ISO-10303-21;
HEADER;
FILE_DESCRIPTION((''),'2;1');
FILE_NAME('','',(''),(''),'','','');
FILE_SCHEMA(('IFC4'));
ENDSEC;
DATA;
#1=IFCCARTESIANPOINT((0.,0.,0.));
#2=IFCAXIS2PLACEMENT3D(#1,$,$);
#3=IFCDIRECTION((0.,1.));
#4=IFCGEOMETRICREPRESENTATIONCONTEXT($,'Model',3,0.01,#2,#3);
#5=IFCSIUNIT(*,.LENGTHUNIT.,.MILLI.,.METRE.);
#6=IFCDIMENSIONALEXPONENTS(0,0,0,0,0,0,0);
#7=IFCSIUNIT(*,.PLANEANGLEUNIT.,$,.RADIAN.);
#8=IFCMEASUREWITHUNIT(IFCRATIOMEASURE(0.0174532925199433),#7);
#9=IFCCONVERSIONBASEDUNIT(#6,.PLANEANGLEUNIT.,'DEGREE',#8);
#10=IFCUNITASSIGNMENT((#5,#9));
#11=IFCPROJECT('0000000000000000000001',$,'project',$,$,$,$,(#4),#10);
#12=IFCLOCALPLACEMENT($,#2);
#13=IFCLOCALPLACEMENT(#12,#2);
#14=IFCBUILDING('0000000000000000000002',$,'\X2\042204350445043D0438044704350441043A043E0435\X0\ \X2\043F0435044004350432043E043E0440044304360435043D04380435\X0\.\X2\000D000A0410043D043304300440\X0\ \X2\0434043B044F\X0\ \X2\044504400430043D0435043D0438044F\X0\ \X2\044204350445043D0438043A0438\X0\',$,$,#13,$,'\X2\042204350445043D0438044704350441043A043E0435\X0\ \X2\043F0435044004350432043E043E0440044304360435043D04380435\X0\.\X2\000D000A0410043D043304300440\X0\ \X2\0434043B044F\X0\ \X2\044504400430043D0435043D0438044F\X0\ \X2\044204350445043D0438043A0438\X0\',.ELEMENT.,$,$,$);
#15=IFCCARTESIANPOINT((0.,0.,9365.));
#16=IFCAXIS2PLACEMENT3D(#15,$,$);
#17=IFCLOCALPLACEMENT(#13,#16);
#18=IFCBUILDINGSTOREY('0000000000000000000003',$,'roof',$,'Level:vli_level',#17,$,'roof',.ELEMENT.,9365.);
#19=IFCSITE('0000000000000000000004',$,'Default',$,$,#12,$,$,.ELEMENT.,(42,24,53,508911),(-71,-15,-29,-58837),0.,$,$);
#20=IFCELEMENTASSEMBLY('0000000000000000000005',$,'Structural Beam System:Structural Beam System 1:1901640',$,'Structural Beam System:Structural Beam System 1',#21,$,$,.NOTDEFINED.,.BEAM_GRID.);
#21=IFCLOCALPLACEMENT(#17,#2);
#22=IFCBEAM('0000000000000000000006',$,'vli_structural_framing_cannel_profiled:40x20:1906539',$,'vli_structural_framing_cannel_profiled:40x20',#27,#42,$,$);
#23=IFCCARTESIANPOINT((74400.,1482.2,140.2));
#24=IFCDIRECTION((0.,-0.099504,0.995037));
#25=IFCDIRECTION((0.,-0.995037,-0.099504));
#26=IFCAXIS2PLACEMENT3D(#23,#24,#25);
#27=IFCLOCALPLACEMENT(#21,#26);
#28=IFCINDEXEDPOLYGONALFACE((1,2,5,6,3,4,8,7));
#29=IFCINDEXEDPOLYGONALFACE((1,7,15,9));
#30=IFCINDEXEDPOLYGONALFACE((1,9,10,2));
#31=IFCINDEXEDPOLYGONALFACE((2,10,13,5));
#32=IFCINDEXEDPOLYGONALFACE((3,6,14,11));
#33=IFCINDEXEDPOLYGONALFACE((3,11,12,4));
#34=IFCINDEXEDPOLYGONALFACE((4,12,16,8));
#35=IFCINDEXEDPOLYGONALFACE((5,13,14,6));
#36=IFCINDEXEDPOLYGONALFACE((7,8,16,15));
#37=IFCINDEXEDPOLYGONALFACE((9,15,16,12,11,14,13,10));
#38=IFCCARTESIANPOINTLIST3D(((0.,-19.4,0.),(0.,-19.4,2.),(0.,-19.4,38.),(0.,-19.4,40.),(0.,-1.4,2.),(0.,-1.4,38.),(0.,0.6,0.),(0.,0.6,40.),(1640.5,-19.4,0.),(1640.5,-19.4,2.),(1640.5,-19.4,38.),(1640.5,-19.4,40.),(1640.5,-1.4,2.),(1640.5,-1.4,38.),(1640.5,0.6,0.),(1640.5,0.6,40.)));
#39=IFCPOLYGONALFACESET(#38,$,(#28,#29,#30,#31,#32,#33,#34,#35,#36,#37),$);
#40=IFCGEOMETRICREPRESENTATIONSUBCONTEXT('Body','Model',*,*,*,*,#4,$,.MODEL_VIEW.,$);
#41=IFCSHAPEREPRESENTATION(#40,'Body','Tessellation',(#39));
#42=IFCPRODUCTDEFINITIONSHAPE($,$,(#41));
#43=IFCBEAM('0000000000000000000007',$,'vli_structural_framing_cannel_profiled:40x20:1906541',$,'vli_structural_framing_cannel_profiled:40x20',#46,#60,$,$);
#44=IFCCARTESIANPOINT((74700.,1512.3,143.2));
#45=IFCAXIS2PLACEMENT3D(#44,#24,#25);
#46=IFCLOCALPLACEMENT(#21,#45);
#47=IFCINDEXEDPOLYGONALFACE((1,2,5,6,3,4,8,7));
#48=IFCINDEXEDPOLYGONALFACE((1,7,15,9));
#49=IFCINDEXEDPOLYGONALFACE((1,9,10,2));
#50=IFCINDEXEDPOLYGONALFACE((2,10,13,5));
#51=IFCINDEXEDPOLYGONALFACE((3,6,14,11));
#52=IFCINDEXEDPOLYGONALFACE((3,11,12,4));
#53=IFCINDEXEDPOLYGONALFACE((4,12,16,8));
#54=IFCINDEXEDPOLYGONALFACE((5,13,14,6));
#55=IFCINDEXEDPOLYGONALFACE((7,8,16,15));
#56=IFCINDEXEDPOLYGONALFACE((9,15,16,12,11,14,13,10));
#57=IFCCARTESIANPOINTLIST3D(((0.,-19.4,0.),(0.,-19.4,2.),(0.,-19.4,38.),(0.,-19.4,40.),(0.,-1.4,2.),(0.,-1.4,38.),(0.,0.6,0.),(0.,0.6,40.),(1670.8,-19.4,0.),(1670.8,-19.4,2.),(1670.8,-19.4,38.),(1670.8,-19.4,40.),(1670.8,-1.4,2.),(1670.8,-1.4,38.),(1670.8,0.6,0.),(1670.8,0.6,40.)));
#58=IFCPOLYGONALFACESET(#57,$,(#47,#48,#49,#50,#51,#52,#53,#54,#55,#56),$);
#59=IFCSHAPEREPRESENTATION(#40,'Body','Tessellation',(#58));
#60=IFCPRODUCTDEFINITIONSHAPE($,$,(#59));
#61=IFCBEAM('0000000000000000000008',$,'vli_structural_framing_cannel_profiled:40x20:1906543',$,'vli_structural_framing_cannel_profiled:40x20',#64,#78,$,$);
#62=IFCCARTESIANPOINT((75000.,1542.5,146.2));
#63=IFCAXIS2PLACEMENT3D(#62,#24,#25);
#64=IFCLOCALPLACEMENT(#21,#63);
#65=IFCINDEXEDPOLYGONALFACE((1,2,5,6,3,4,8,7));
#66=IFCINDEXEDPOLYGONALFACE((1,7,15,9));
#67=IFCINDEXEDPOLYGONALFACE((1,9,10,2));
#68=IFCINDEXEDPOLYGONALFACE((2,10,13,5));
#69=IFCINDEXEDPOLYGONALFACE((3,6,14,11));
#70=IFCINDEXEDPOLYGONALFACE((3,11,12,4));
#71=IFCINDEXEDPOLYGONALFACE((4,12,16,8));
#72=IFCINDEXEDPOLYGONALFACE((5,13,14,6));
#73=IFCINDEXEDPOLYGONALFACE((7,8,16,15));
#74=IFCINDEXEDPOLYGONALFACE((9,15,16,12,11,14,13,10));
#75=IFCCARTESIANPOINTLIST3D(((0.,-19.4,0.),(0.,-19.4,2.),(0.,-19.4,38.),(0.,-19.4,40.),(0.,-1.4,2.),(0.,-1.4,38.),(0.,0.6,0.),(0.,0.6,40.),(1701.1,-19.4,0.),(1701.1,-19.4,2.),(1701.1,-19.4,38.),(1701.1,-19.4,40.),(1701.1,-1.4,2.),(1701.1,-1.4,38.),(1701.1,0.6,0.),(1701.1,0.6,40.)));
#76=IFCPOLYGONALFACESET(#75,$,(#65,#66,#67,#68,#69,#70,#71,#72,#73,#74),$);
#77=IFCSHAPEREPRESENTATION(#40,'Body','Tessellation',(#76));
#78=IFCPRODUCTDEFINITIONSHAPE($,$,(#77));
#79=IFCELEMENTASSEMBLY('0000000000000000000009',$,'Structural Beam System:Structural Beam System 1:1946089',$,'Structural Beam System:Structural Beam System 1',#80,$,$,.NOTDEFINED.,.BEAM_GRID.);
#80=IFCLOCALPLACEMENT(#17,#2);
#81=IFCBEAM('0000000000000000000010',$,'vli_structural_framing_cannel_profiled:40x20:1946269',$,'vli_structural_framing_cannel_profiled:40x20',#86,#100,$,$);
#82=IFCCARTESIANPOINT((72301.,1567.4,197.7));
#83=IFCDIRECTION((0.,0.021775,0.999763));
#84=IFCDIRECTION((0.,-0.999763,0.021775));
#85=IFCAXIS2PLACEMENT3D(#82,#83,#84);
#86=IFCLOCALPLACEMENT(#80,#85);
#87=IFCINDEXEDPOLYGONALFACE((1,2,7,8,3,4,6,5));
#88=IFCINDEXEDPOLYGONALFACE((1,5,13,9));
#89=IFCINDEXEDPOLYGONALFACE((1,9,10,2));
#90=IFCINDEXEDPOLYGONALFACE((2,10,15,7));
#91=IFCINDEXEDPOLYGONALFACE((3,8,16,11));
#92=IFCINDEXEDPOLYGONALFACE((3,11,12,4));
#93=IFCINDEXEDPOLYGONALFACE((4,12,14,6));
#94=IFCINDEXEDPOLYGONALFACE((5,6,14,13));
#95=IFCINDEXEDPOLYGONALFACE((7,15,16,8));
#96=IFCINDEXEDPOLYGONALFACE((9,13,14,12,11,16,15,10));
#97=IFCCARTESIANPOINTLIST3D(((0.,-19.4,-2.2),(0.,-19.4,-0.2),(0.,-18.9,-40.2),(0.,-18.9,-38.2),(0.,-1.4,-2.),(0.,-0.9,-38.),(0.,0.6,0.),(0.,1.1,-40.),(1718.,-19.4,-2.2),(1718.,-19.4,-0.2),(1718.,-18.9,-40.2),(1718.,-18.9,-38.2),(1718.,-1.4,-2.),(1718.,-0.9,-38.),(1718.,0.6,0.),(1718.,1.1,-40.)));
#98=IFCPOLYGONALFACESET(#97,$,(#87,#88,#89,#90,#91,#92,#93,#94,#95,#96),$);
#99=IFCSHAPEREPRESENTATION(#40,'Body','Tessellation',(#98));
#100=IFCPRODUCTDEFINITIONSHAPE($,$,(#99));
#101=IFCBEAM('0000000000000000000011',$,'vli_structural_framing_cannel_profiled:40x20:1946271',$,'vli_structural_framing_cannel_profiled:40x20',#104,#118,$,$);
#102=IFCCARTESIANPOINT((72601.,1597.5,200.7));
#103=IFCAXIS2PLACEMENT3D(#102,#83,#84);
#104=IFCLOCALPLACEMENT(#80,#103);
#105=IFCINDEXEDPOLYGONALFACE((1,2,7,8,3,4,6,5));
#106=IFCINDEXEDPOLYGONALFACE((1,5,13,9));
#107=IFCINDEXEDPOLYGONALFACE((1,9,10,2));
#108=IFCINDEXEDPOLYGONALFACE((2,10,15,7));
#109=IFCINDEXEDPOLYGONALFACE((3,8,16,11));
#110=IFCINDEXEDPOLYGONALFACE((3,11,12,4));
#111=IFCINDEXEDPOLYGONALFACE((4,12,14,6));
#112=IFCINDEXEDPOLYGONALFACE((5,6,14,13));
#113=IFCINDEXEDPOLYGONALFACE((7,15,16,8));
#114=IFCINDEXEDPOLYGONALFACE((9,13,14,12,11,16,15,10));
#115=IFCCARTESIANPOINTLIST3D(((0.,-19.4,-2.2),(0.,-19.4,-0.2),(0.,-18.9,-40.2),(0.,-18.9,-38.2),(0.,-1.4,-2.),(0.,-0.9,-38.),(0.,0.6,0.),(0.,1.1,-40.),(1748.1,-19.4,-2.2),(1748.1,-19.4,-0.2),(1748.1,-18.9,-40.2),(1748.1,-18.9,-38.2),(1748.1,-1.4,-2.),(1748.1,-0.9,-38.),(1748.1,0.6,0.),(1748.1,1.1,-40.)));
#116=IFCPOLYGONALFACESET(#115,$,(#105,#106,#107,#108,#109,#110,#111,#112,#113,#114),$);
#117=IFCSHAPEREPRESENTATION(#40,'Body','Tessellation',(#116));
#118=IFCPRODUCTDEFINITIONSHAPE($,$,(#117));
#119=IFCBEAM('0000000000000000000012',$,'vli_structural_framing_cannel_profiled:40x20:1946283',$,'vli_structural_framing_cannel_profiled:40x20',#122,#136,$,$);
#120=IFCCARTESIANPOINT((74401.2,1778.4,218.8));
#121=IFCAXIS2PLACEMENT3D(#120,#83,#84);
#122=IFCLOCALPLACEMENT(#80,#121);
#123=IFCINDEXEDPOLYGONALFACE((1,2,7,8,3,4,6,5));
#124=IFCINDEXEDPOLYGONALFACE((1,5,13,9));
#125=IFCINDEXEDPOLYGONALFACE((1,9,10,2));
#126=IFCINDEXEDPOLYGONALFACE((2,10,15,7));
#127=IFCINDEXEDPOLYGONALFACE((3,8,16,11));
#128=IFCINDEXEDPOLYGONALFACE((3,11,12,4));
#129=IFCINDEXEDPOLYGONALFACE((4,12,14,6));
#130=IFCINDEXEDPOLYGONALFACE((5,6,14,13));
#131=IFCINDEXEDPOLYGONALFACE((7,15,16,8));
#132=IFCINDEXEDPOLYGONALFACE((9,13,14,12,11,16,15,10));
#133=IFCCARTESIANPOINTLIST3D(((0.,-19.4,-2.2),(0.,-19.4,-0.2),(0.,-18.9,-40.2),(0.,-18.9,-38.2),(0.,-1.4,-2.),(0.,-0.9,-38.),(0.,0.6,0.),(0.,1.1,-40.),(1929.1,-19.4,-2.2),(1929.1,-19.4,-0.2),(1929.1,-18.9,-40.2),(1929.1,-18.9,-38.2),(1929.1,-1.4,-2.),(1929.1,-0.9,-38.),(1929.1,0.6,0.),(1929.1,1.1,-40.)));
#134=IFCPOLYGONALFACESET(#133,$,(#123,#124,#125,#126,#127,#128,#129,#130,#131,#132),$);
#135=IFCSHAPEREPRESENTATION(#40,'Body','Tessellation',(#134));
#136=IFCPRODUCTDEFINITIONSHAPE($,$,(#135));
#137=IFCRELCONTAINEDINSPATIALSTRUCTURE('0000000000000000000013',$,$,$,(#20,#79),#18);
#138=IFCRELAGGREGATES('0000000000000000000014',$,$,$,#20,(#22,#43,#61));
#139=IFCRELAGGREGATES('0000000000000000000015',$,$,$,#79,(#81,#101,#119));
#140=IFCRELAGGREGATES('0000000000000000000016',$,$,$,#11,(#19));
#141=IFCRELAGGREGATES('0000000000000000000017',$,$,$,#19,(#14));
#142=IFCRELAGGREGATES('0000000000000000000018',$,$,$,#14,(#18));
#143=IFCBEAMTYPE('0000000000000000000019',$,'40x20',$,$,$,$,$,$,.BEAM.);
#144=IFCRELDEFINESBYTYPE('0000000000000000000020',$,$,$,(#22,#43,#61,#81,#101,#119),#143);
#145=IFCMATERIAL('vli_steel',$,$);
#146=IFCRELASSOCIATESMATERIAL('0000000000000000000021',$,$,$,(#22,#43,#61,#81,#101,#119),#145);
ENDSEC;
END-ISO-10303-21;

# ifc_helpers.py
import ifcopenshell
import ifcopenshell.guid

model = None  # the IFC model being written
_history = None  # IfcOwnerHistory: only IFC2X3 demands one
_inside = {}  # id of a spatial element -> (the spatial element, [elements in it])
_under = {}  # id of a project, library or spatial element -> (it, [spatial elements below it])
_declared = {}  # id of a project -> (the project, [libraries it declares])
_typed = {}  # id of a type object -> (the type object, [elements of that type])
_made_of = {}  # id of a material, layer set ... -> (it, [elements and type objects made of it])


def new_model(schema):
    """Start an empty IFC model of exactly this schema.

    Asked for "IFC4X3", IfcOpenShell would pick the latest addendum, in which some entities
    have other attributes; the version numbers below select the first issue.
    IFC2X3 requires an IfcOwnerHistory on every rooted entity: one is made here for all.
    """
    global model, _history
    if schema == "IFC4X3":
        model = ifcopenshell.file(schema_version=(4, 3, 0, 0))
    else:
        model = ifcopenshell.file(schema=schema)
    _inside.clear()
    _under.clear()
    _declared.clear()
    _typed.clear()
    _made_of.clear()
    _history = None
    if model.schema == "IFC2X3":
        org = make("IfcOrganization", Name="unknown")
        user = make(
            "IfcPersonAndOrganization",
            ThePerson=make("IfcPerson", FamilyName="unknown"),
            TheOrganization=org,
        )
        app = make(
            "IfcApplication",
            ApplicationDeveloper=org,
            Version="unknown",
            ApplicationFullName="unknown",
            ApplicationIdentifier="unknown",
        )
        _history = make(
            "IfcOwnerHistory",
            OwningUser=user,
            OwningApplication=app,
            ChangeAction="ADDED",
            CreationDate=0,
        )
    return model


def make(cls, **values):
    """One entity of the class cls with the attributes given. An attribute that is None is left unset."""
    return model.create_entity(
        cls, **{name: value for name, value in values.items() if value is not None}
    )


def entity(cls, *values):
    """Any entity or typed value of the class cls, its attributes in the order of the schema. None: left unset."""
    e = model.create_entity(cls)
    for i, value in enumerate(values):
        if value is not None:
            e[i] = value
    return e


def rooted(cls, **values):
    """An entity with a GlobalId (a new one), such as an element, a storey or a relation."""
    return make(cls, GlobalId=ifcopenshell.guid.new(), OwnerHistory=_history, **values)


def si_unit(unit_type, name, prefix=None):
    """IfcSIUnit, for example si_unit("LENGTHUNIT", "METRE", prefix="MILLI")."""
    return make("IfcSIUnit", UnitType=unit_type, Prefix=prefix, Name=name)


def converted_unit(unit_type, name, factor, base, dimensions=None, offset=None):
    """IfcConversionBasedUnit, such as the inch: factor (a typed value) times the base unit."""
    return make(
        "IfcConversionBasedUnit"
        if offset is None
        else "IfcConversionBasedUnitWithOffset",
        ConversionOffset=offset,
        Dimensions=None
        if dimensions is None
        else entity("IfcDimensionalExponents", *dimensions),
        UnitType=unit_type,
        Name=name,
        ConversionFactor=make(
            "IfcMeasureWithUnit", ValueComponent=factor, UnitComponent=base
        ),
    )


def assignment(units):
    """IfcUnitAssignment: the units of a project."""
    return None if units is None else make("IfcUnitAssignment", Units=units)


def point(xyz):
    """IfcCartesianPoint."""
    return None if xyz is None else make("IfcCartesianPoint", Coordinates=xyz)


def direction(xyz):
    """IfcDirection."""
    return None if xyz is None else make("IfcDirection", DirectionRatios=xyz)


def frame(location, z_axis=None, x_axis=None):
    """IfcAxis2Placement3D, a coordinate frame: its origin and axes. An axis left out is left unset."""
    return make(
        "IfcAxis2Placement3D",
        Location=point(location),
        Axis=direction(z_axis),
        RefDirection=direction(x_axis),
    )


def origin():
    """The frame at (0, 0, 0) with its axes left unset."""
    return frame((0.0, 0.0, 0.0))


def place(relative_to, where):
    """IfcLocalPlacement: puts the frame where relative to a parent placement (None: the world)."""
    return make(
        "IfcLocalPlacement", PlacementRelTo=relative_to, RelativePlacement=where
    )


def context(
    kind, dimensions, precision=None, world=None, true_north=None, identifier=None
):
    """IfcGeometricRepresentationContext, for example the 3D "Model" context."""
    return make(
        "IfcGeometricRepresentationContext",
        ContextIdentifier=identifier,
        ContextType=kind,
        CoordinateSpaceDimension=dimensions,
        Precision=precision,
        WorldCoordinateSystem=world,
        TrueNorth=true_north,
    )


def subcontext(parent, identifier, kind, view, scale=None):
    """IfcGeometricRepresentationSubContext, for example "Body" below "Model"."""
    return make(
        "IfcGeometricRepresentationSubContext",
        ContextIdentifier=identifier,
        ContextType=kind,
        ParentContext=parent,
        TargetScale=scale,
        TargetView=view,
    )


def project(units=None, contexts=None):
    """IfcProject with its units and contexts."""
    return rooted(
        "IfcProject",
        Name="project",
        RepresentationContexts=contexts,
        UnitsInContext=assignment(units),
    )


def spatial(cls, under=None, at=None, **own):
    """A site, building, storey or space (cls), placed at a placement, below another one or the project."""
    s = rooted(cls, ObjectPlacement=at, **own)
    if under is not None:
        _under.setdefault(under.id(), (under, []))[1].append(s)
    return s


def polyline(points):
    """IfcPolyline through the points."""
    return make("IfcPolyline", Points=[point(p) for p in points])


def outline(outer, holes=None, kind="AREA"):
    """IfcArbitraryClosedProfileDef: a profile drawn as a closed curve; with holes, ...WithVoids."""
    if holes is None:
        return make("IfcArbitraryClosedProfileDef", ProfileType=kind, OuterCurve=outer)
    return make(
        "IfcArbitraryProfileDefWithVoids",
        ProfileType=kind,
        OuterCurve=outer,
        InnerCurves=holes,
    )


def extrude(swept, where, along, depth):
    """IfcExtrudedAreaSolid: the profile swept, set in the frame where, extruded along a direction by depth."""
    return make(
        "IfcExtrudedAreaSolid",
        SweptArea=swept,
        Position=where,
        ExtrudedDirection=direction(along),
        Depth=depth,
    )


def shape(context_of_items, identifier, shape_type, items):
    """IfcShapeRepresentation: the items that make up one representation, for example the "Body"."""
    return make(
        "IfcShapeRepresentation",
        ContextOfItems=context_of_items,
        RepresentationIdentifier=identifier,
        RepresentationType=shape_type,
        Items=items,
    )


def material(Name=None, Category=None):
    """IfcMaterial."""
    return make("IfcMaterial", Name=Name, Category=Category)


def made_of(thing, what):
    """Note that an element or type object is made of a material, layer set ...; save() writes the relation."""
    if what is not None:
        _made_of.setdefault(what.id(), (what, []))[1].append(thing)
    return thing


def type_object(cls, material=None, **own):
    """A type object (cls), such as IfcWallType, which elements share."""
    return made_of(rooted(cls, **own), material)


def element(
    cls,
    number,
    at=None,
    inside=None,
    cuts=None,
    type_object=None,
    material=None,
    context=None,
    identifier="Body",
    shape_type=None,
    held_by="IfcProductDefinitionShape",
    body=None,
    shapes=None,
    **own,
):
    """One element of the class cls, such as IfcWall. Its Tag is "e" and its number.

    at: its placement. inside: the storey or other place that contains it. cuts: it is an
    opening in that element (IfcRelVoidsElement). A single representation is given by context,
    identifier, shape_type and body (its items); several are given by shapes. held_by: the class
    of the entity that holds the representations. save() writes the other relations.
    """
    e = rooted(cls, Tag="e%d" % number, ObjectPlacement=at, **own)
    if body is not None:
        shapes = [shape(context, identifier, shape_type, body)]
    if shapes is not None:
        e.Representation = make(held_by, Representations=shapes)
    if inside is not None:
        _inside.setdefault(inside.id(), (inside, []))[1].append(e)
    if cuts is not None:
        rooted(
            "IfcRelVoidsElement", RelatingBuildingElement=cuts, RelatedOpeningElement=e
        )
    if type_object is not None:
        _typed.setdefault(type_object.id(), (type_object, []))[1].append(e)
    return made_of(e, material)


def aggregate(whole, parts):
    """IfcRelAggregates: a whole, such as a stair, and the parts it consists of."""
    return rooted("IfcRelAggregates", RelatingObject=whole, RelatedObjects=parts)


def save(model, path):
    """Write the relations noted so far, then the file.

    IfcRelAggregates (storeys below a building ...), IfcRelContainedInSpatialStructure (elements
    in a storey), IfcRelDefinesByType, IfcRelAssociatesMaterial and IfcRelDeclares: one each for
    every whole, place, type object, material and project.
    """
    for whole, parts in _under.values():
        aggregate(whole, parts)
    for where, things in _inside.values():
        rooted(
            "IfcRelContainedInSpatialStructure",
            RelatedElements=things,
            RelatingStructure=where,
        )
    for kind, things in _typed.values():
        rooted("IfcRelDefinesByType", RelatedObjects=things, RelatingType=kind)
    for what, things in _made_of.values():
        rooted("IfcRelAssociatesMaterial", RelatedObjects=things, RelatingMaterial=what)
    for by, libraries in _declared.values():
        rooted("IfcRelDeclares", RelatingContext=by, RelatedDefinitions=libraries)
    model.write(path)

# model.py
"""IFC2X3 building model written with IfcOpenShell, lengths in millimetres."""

from ifc_helpers import new_model, entity, si_unit, converted_unit, direction, frame, origin, place, context, subcontext, project, spatial, polyline, outline, extrude, material, type_object, element, aggregate, save


model = new_model("IFC2X3")

# Units and contexts
model_context = context("Model", 3, precision=0.01, world=origin(), true_north=direction((0.0, 1.0)))
body_context = subcontext(model_context, "Body", "Model", "MODEL_VIEW")
ifc_project = project(units=[si_unit("LENGTHUNIT", "METRE", prefix="MILLI"), converted_unit("PLANEANGLEUNIT", "DEGREE", entity("IfcRatioMeasure", 0.0174532925199433), si_unit("PLANEANGLEUNIT", "RADIAN"), dimensions=[0, 0, 0, 0, 0, 0, 0])], contexts=[model_context])

# Site, building, storey
site_placement = place(None, origin())
site = spatial("IfcSite", under=ifc_project, at=site_placement, Name="Default", CompositionType="ELEMENT", RefLatitude=(42, 24, 53, 508911), RefLongitude=(-71, -15, -29, -58837), RefElevation=0.0)
building_placement = place(site_placement, origin())
building = spatial("IfcBuilding", under=site, at=building_placement, Name="Техническое перевооружение.\r\nАнгар для хранения техники", LongName="Техническое перевооружение.\r\nАнгар для хранения техники", CompositionType="ELEMENT")
storey_placement = place(building_placement, frame((0.0, 0.0, 9365.0)))
storey = spatial("IfcBuildingStorey", under=building, at=storey_placement, Name="roof", ObjectType="Level:vli_level", LongName="roof", CompositionType="ELEMENT", Elevation=9365.0)

# Element assemblies, beams
assembly_1_placement = place(storey_placement, origin())
assembly_1 = element("IfcElementAssembly", 1, at=assembly_1_placement, inside=storey, Name="Structural Beam System:Structural Beam System 1:1901640", ObjectType="Structural Beam System:Structural Beam System 1", AssemblyPlace="NOTDEFINED", PredefinedType="BEAM_GRID")
ifc_material = material(Name="vli_steel")
beam_type = type_object("IfcBeamType", Name="40x20", PredefinedType="BEAM")
beam_1_placement = place(assembly_1_placement, frame((74400.0, 1482.2, 140.2), z_axis=(0.0, -0.099504, 0.995037), x_axis=(0.0, -0.995037, -0.099504)))
beam_1 = element("IfcBeam", 2, at=beam_1_placement, type_object=beam_type, material=ifc_material, Name="vli_structural_framing_cannel_profiled:40x20:1906539", ObjectType="vli_structural_framing_cannel_profiled:40x20", context=body_context, shape_type="SweptSolid", body=[
    extrude(outline(polyline([(-20.0, -9.5), (-18.0, -9.5), (-18.0, 8.5), (18.0, 8.5), (18.0, -9.5), (20.0, -9.5), (20.0, 10.5), (-20.0, 10.5), (-20.0, -9.5)])), frame((0.0, -9.9, 20.0), z_axis=(1.0, 0.0, 0.0), x_axis=(0.0, 0.0, -1.0)), (0.0, 0.0, 1.0), 1640.5),
])
beam_2_placement = place(assembly_1_placement, frame((74700.0, 1512.3, 143.2), z_axis=(0.0, -0.099504, 0.995037), x_axis=(0.0, -0.995037, -0.099504)))
beam_2 = element("IfcBeam", 3, at=beam_2_placement, type_object=beam_type, material=ifc_material, Name="vli_structural_framing_cannel_profiled:40x20:1906541", ObjectType="vli_structural_framing_cannel_profiled:40x20", context=body_context, shape_type="SweptSolid", body=[
    extrude(outline(polyline([(-20.0, -9.5), (-18.0, -9.5), (-18.0, 8.5), (18.0, 8.5), (18.0, -9.5), (20.0, -9.5), (20.0, 10.5), (-20.0, 10.5), (-20.0, -9.5)])), frame((0.0, -9.9, 20.0), z_axis=(1.0, 0.0, 0.0), x_axis=(0.0, 0.0, -1.0)), (0.0, 0.0, 1.0), 1670.8),
])
beam_3_placement = place(assembly_1_placement, frame((75000.0, 1542.5, 146.2), z_axis=(0.0, -0.099504, 0.995037), x_axis=(0.0, -0.995037, -0.099504)))
beam_3 = element("IfcBeam", 4, at=beam_3_placement, type_object=beam_type, material=ifc_material, Name="vli_structural_framing_cannel_profiled:40x20:1906543", ObjectType="vli_structural_framing_cannel_profiled:40x20", context=body_context, shape_type="SweptSolid", body=[
    extrude(outline(polyline([(-20.0, -9.5), (-18.0, -9.5), (-18.0, 8.5), (18.0, 8.5), (18.0, -9.5), (20.0, -9.5), (20.0, 10.5), (-20.0, 10.5), (-20.0, -9.5)])), frame((0.0, -9.9, 20.0), z_axis=(1.0, 0.0, 0.0), x_axis=(0.0, 0.0, -1.0)), (0.0, 0.0, 1.0), 1701.1),
])
aggregate(assembly_1, [beam_1, beam_2, beam_3])
assembly_2_placement = place(storey_placement, origin())
assembly_2 = element("IfcElementAssembly", 5, at=assembly_2_placement, inside=storey, Name="Structural Beam System:Structural Beam System 1:1946089", ObjectType="Structural Beam System:Structural Beam System 1", AssemblyPlace="NOTDEFINED", PredefinedType="BEAM_GRID")
beam_4_placement = place(assembly_2_placement, frame((72301.0, 1567.4, 197.7), z_axis=(0.0, 0.021775, 0.999763), x_axis=(0.0, -0.999763, 0.021775)))
beam_4 = element("IfcBeam", 6, at=beam_4_placement, type_object=beam_type, material=ifc_material, Name="vli_structural_framing_cannel_profiled:40x20:1946269", ObjectType="vli_structural_framing_cannel_profiled:40x20", context=body_context, shape_type="SweptSolid", body=[
    extrude(outline(polyline([(-10.5, -20.0), (9.5, -20.0), (9.5, -18.0), (-8.5, -18.0), (-8.5, 18.0), (9.5, 18.0), (9.5, 20.0), (-10.5, 20.0), (-10.5, -20.0)])), frame((0.0, -9.7, -20.1), z_axis=(1.0, 0.0, 0.0), x_axis=(0.0, -0.999925, -0.01227)), (0.0, 0.0, 1.0), 1718.0),
])
beam_5_placement = place(assembly_2_placement, frame((72601.0, 1597.5, 200.7), z_axis=(0.0, 0.021775, 0.999763), x_axis=(0.0, -0.999763, 0.021775)))
beam_5 = element("IfcBeam", 7, at=beam_5_placement, type_object=beam_type, material=ifc_material, Name="vli_structural_framing_cannel_profiled:40x20:1946271", ObjectType="vli_structural_framing_cannel_profiled:40x20", context=body_context, shape_type="SweptSolid", body=[
    extrude(outline(polyline([(-10.5, -20.0), (9.5, -20.0), (9.5, -18.0), (-8.5, -18.0), (-8.5, 18.0), (9.5, 18.0), (9.5, 20.0), (-10.5, 20.0), (-10.5, -20.0)])), frame((0.0, -9.7, -20.1), z_axis=(1.0, 0.0, 0.0), x_axis=(0.0, -0.999925, -0.01227)), (0.0, 0.0, 1.0), 1748.1),
])
beam_6_placement = place(assembly_2_placement, frame((74401.2, 1778.4, 218.8), z_axis=(0.0, 0.021775, 0.999763), x_axis=(0.0, -0.999763, 0.021775)))
beam_6 = element("IfcBeam", 8, at=beam_6_placement, type_object=beam_type, material=ifc_material, Name="vli_structural_framing_cannel_profiled:40x20:1946283", ObjectType="vli_structural_framing_cannel_profiled:40x20", context=body_context, shape_type="SweptSolid", body=[
    extrude(outline(polyline([(-10.5, -20.0), (9.5, -20.0), (9.5, -18.0), (-8.5, -18.0), (-8.5, 18.0), (9.5, 18.0), (9.5, 20.0), (-10.5, 20.0), (-10.5, -20.0)])), frame((0.0, -9.7, -20.1), z_axis=(1.0, 0.0, 0.0), x_axis=(0.0, -0.999925, -0.01227)), (0.0, 0.0, 1.0), 1929.1),
])
aggregate(assembly_2, [beam_4, beam_5, beam_6])

save(model, "model.ifc")
